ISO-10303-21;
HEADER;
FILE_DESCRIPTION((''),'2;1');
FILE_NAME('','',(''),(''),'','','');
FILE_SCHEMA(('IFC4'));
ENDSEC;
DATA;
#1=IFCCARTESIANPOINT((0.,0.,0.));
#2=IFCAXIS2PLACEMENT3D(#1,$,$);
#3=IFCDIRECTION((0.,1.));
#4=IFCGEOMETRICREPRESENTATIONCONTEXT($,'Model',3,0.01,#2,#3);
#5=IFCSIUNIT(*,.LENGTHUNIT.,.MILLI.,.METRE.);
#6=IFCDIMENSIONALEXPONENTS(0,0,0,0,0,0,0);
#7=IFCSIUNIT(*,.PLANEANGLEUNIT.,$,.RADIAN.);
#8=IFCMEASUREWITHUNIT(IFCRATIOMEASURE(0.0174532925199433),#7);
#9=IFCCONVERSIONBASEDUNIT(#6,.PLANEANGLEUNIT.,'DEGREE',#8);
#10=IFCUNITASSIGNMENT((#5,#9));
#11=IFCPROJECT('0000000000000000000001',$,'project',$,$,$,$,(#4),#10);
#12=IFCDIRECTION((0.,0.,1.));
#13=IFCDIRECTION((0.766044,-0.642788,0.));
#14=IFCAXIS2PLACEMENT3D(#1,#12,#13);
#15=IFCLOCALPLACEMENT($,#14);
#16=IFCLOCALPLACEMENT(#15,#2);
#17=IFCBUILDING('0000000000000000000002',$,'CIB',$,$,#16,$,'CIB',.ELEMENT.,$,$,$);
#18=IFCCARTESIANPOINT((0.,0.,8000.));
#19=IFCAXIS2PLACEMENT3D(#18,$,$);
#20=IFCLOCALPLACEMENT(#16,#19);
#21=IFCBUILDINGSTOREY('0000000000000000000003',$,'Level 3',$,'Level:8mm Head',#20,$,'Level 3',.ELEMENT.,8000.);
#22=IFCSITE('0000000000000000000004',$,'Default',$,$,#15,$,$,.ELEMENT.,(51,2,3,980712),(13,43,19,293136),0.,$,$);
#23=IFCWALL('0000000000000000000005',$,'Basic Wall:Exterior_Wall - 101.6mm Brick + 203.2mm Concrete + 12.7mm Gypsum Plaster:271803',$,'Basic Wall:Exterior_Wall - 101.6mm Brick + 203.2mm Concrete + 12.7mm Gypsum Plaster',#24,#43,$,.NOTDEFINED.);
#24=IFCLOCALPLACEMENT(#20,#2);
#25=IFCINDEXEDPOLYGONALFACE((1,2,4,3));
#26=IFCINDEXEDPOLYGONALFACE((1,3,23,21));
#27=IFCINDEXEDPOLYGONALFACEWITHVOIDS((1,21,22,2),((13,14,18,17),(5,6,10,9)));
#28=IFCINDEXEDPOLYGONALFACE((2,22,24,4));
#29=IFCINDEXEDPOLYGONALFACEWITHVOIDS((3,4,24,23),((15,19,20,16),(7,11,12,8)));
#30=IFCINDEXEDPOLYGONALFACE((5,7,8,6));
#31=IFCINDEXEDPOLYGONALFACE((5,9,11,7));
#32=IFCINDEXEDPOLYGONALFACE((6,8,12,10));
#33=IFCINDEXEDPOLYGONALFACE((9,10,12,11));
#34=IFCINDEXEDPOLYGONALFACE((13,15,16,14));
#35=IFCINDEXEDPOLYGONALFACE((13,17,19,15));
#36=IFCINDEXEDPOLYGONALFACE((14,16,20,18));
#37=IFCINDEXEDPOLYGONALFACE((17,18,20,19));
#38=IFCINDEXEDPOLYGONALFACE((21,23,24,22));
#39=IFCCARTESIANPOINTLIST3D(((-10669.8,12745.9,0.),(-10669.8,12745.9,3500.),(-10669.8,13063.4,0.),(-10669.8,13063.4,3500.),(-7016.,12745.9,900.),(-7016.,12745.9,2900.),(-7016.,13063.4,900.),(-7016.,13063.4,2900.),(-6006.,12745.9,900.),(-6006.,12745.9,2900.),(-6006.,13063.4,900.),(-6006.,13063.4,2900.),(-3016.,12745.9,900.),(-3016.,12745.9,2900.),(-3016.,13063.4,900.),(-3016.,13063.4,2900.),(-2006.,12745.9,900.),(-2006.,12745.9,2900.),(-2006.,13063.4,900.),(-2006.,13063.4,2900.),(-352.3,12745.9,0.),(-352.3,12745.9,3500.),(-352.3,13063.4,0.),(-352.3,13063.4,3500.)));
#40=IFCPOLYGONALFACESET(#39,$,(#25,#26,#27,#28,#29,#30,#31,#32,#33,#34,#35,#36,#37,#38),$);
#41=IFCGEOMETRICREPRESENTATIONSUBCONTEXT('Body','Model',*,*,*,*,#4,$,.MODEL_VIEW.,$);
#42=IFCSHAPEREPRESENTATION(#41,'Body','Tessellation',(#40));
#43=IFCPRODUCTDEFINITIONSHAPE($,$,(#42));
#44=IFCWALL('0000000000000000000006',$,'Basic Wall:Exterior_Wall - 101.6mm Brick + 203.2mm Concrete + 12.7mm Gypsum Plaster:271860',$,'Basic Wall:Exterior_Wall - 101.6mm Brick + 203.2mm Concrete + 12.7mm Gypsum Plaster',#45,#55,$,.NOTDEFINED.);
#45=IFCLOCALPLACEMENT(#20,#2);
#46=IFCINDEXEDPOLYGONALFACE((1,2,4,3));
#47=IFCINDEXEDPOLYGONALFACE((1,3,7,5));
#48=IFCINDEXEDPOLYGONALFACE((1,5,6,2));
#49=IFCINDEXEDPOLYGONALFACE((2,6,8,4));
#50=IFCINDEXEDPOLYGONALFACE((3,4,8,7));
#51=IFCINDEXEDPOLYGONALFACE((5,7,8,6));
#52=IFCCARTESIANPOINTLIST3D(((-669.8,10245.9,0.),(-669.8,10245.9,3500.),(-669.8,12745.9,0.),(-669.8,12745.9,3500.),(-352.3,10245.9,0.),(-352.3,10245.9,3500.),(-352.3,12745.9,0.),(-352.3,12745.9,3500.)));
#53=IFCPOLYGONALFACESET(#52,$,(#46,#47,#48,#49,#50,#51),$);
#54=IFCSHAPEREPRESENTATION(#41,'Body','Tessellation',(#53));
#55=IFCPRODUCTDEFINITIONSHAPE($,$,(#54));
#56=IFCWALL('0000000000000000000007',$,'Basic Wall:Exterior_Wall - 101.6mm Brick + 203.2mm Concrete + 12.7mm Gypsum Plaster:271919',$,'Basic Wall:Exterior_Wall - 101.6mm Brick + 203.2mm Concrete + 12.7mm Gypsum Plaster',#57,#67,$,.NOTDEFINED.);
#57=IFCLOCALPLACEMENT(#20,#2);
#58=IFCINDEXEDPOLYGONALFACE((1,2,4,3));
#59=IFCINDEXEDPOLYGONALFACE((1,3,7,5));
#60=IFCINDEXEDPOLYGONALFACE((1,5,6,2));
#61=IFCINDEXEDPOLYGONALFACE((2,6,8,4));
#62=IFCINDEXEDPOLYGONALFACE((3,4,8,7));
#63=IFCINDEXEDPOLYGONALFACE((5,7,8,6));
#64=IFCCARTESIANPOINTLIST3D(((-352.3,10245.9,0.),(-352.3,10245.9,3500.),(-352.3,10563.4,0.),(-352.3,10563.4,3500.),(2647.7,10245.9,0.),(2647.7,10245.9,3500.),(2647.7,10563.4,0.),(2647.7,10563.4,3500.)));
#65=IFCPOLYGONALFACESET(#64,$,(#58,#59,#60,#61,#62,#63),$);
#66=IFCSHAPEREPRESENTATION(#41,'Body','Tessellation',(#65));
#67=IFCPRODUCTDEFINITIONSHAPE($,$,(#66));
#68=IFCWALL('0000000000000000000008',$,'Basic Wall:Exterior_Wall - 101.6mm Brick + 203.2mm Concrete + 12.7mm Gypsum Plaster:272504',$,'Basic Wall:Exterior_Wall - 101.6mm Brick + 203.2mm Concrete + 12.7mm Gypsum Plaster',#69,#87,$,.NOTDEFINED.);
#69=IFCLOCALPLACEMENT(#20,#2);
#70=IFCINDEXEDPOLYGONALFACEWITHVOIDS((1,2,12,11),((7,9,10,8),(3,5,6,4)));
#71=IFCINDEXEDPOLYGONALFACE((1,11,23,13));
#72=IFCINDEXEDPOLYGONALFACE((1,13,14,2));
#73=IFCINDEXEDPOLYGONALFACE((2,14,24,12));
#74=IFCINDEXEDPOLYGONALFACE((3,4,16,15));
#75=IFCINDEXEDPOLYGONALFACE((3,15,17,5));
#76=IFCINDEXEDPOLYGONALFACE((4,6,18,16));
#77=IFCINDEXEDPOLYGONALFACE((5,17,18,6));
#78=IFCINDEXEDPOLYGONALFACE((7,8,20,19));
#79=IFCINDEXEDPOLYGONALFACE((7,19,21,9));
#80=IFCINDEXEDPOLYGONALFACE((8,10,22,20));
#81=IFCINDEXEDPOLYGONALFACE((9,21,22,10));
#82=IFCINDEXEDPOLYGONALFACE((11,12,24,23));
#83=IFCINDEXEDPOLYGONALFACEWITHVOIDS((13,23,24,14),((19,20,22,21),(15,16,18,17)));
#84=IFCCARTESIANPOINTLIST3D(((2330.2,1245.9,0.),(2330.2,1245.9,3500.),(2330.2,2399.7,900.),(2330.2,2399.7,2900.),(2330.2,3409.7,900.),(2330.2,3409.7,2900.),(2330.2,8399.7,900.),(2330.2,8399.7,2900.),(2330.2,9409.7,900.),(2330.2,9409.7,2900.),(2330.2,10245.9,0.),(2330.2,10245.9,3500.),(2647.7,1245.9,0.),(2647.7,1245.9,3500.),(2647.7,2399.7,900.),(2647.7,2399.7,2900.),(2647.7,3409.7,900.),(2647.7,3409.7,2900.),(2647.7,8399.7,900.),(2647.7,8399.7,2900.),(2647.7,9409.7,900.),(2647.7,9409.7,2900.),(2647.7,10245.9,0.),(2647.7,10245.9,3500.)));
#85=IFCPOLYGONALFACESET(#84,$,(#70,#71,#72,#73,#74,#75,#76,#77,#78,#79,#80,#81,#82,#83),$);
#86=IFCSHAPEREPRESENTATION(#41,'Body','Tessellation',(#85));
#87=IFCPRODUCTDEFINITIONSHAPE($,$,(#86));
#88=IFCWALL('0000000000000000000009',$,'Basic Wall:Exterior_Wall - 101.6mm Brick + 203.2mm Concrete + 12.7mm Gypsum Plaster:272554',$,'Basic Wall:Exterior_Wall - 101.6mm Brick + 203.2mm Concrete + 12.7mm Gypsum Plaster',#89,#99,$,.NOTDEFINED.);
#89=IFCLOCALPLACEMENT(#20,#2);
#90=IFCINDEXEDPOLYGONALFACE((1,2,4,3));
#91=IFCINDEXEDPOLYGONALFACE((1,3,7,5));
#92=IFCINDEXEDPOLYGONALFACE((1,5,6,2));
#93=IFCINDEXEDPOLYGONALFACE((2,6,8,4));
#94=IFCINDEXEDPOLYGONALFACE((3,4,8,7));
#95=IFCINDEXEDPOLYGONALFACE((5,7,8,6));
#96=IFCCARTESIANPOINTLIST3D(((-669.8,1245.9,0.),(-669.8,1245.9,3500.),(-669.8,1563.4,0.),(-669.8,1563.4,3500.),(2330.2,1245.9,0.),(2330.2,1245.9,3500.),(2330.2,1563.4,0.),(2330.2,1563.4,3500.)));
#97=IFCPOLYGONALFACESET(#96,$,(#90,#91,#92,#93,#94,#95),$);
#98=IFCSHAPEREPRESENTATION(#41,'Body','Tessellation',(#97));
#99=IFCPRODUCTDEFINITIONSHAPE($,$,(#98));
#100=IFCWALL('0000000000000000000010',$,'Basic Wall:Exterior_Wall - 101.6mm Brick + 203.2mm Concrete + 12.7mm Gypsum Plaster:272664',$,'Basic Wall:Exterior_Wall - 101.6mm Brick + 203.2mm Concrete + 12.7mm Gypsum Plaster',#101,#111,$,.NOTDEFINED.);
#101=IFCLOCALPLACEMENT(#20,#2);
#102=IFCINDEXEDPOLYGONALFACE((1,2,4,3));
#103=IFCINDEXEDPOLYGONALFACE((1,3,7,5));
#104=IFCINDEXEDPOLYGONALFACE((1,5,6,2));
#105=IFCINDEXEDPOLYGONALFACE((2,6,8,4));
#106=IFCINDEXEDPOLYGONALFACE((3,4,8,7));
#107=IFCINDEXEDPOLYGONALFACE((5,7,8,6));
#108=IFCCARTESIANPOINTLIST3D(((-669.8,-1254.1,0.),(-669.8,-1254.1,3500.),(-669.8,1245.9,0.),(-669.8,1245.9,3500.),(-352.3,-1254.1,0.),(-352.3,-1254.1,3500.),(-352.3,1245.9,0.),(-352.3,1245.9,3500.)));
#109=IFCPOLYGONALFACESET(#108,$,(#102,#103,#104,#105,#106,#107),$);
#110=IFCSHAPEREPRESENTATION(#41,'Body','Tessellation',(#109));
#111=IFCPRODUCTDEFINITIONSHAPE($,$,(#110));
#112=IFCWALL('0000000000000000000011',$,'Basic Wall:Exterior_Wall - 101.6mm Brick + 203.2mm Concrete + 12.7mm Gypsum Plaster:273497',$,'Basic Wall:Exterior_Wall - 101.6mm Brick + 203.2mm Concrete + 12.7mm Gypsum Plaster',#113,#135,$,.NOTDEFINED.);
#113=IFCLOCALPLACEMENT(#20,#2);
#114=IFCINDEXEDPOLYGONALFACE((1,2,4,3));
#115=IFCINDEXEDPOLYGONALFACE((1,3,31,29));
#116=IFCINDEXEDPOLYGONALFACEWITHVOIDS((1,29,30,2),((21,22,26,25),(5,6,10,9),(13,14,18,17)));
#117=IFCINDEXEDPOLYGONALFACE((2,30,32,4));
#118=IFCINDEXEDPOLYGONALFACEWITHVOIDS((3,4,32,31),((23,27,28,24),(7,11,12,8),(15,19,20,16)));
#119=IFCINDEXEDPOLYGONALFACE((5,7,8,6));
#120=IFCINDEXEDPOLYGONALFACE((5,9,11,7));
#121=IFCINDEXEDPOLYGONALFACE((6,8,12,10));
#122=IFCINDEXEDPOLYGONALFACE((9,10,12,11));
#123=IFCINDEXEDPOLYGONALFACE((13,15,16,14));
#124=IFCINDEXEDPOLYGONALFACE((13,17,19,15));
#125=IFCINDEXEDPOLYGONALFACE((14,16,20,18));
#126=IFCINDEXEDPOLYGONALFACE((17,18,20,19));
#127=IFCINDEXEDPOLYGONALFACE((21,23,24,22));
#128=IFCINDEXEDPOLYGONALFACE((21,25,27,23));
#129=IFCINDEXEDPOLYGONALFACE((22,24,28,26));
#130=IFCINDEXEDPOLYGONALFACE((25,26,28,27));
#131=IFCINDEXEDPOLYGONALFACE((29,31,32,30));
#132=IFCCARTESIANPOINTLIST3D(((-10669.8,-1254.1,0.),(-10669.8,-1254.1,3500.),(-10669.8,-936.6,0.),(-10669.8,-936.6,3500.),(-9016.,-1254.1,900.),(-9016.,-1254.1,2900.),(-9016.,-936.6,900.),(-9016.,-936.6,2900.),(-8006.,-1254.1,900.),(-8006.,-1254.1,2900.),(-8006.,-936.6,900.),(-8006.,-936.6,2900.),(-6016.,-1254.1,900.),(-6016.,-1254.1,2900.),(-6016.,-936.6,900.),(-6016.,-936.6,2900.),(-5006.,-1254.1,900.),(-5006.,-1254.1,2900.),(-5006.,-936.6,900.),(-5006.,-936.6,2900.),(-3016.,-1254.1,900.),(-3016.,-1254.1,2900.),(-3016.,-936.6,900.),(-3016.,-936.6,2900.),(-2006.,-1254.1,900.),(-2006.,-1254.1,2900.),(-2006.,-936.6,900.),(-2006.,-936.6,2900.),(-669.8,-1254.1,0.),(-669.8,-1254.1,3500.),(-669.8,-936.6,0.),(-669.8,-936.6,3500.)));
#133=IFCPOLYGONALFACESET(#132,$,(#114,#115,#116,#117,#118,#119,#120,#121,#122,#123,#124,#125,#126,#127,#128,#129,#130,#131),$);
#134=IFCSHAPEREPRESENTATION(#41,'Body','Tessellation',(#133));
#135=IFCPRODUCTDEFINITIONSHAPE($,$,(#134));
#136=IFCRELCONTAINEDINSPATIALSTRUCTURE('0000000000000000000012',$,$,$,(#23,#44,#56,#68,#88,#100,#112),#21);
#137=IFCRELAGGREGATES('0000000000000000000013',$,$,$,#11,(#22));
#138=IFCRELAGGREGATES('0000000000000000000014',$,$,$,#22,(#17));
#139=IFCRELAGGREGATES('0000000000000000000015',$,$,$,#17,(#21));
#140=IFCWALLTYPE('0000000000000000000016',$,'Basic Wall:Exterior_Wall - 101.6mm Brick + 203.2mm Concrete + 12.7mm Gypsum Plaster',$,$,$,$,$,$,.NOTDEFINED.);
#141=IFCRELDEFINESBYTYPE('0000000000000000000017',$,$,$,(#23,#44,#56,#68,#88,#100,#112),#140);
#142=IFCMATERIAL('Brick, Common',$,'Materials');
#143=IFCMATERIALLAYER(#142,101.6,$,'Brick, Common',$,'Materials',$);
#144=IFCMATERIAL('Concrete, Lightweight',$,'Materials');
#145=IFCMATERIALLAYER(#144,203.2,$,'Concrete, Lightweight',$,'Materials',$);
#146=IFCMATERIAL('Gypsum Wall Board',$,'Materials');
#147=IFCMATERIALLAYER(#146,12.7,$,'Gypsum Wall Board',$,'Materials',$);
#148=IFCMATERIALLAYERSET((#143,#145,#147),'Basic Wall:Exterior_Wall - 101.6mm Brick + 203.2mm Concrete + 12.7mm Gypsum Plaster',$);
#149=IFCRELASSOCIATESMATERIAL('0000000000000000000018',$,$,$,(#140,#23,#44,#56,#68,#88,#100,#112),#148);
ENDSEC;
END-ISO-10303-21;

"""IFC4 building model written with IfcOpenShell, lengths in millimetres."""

from ifc_helpers import new_model, entity, si_unit, converted_unit, direction, frame, frame_2d, origin, place, context, subcontext, project, spatial, rectangle, extrude, material, layer, layer_set, layer_usage, type_object, element, save


model = new_model("IFC4")

# Units and contexts
model_context = context("Model", 3, precision=0.01, world=origin(), true_north=direction((0.0, 1.0)))
body_context = subcontext(model_context, "Body", "Model", "MODEL_VIEW")
ifc_project = project(units=[si_unit("LENGTHUNIT", "METRE", prefix="MILLI"), converted_unit("PLANEANGLEUNIT", "DEGREE", entity("IfcRatioMeasure", 0.0174532925199433), si_unit("PLANEANGLEUNIT", "RADIAN"), dimensions=[0, 0, 0, 0, 0, 0, 0])], contexts=[model_context])

# Site, building, storey
site_placement = place(None, frame((0.0, 0.0, 0.0), z_axis=(0.0, 0.0, 1.0), x_axis=(0.766044, -0.642788, 0.0)))
site = spatial("IfcSite", under=ifc_project, at=site_placement, Name="Default", CompositionType="ELEMENT", RefLatitude=(51, 2, 3, 980712), RefLongitude=(13, 43, 19, 293136), RefElevation=0.0)
building_placement = place(site_placement, origin())
building = spatial("IfcBuilding", under=site, at=building_placement, Name="CIB", LongName="CIB", CompositionType="ELEMENT")
storey_placement = place(building_placement, frame((0.0, 0.0, 8000.0)))
storey = spatial("IfcBuildingStorey", under=building, at=storey_placement, Name="Level 3", ObjectType="Level:8mm Head", LongName="Level 3", CompositionType="ELEMENT", Elevation=8000.0)

# Wall, openings
ifc_material_1 = material(Name="Brick, Common", Category="Materials")
ifc_layer_1 = layer(ifc_material_1, 101.6, Name="Brick, Common", Category="Materials")
ifc_material_2 = material(Name="Concrete, Lightweight", Category="Materials")
ifc_layer_2 = layer(ifc_material_2, 203.2, Name="Concrete, Lightweight", Category="Materials")
ifc_material_3 = material(Name="Gypsum Wall Board", Category="Materials")
ifc_layer_3 = layer(ifc_material_3, 12.7, Name="Gypsum Wall Board", Category="Materials")
ifc_layer_set_1 = layer_set([ifc_layer_1, ifc_layer_2, ifc_layer_3], Name="Basic Wall:Exterior_Wall - 101.6mm Brick + 203.2mm Concrete + 12.7mm Gypsum Plaster")
ifc_layer_usage_1 = layer_usage(ifc_layer_set_1, "AXIS2", "NEGATIVE", 158.8)
wall_type_1 = type_object("IfcWallType", Name="Basic Wall:Exterior_Wall - 101.6mm Brick + 203.2mm Concrete + 12.7mm Gypsum Plaster", PredefinedType="NOTDEFINED", material=ifc_layer_set_1)
wall_1_placement = place(storey_placement, frame((-10669.8, 12904.7, 0.0)))
wall_1 = element("IfcWall", 1, at=wall_1_placement, inside=storey, type_object=wall_type_1, material=ifc_layer_usage_1, Name="Basic Wall:Exterior_Wall - 101.6mm Brick + 203.2mm Concrete + 12.7mm Gypsum Plaster:271803", ObjectType="Basic Wall:Exterior_Wall - 101.6mm Brick + 203.2mm Concrete + 12.7mm Gypsum Plaster", PredefinedType="NOTDEFINED", context=body_context, shape_type="SweptSolid", body=[
    extrude(rectangle(XDim=10317.5, YDim=317.5, at=frame_2d((5158.7, 0.0), x_axis=(-1.0, 0.0))), origin(), (0.0, 0.0, 1.0), 3500.0),
])
opening_1_placement = place(wall_1_placement, frame((8663.7, 158.7, 900.0)))
element("IfcOpeningElement", 2, at=opening_1_placement, cuts=wall_1, ObjectType="Opening", PredefinedType="OPENING", context=body_context, shape_type="SweptSolid", body=[
    extrude(rectangle(XDim=2000.0, YDim=1010.0, at=frame_2d((1000.0, 505.0), x_axis=(1.0, 0.0))), frame((0.0, 0.0, 0.0), z_axis=(0.0, -1.0, 0.0), x_axis=(0.0, 0.0, 1.0)), (0.0, 0.0, 1.0), 317.5),
])
opening_2_placement = place(wall_1_placement, frame((4663.7, 158.7, 900.0)))
element("IfcOpeningElement", 3, at=opening_2_placement, cuts=wall_1, ObjectType="Opening", PredefinedType="OPENING", context=body_context, shape_type="SweptSolid", body=[
    extrude(rectangle(XDim=2000.0, YDim=1010.0, at=frame_2d((1000.0, 505.0), x_axis=(1.0, 0.0))), frame((0.0, 0.0, 0.0), z_axis=(0.0, -1.0, 0.0), x_axis=(0.0, 0.0, 1.0)), (0.0, 0.0, 1.0), 317.5),
])

# Walls
ifc_layer_usage_2 = layer_usage(ifc_layer_set_1, "AXIS2", "NEGATIVE", 158.8)
wall_2_placement = place(storey_placement, frame((-511.0, 12745.9, 0.0), z_axis=(0.0, 0.0, 1.0), x_axis=(0.0, -1.0, 0.0)))
element("IfcWall", 4, at=wall_2_placement, inside=storey, type_object=wall_type_1, material=ifc_layer_usage_2, Name="Basic Wall:Exterior_Wall - 101.6mm Brick + 203.2mm Concrete + 12.7mm Gypsum Plaster:271860", ObjectType="Basic Wall:Exterior_Wall - 101.6mm Brick + 203.2mm Concrete + 12.7mm Gypsum Plaster", PredefinedType="NOTDEFINED", context=body_context, shape_type="SweptSolid", body=[
    extrude(rectangle(XDim=2500.0, YDim=317.5, at=frame_2d((1250.0, 0.0), x_axis=(-1.0, 0.0))), origin(), (0.0, 0.0, 1.0), 3500.0),
])
ifc_layer_usage_3 = layer_usage(ifc_layer_set_1, "AXIS2", "NEGATIVE", 158.8)
wall_3_placement = place(storey_placement, frame((-352.3, 10404.7, 0.0)))
element("IfcWall", 5, at=wall_3_placement, inside=storey, type_object=wall_type_1, material=ifc_layer_usage_3, Name="Basic Wall:Exterior_Wall - 101.6mm Brick + 203.2mm Concrete + 12.7mm Gypsum Plaster:271919", ObjectType="Basic Wall:Exterior_Wall - 101.6mm Brick + 203.2mm Concrete + 12.7mm Gypsum Plaster", PredefinedType="NOTDEFINED", context=body_context, shape_type="SweptSolid", body=[
    extrude(rectangle(XDim=3000.0, YDim=317.5, at=frame_2d((1500.0, 0.0), x_axis=(-1.0, 0.0))), origin(), (0.0, 0.0, 1.0), 3500.0),
])

# Wall, openings
ifc_layer_usage_4 = layer_usage(ifc_layer_set_1, "AXIS2", "NEGATIVE", 158.8)
wall_4_placement = place(storey_placement, frame((2489.0, 10245.9, 0.0), z_axis=(0.0, 0.0, 1.0), x_axis=(0.0, -1.0, 0.0)))
wall_4 = element("IfcWall", 6, at=wall_4_placement, inside=storey, type_object=wall_type_1, material=ifc_layer_usage_4, Name="Basic Wall:Exterior_Wall - 101.6mm Brick + 203.2mm Concrete + 12.7mm Gypsum Plaster:272504", ObjectType="Basic Wall:Exterior_Wall - 101.6mm Brick + 203.2mm Concrete + 12.7mm Gypsum Plaster", PredefinedType="NOTDEFINED", context=body_context, shape_type="SweptSolid", body=[
    extrude(rectangle(XDim=9000.0, YDim=317.5, at=frame_2d((4500.0, 0.0), x_axis=(-1.0, 0.0))), origin(), (0.0, 0.0, 1.0), 3500.0),
])
opening_3_placement = place(wall_4_placement, frame((1846.2, 158.7, 900.0)))
element("IfcOpeningElement", 7, at=opening_3_placement, cuts=wall_4, ObjectType="Opening", PredefinedType="OPENING", context=body_context, shape_type="SweptSolid", body=[
    extrude(rectangle(XDim=2000.0, YDim=1010.0, at=frame_2d((1000.0, 505.0), x_axis=(1.0, 0.0))), frame((0.0, 0.0, 0.0), z_axis=(0.0, -1.0, 0.0), x_axis=(0.0, 0.0, 1.0)), (0.0, 0.0, 1.0), 317.5),
])
opening_4_placement = place(wall_4_placement, frame((7846.2, 158.7, 900.0)))
element("IfcOpeningElement", 8, at=opening_4_placement, cuts=wall_4, ObjectType="Opening", PredefinedType="OPENING", context=body_context, shape_type="SweptSolid", body=[
    extrude(rectangle(XDim=2000.0, YDim=1010.0, at=frame_2d((1000.0, 505.0), x_axis=(1.0, 0.0))), frame((0.0, 0.0, 0.0), z_axis=(0.0, -1.0, 0.0), x_axis=(0.0, 0.0, 1.0)), (0.0, 0.0, 1.0), 317.5),
])

# Walls
ifc_layer_usage_5 = layer_usage(ifc_layer_set_1, "AXIS2", "NEGATIVE", 158.8)
wall_5_placement = place(storey_placement, frame((2330.2, 1404.7, 0.0), z_axis=(0.0, 0.0, 1.0), x_axis=(-1.0, 0.0, 0.0)))
element("IfcWall", 9, at=wall_5_placement, inside=storey, type_object=wall_type_1, material=ifc_layer_usage_5, Name="Basic Wall:Exterior_Wall - 101.6mm Brick + 203.2mm Concrete + 12.7mm Gypsum Plaster:272554", ObjectType="Basic Wall:Exterior_Wall - 101.6mm Brick + 203.2mm Concrete + 12.7mm Gypsum Plaster", PredefinedType="NOTDEFINED", context=body_context, shape_type="SweptSolid", body=[
    extrude(rectangle(XDim=3000.0, YDim=317.5, at=frame_2d((1500.0, 0.0), x_axis=(-1.0, 0.0))), origin(), (0.0, 0.0, 1.0), 3500.0),
])
ifc_layer_usage_6 = layer_usage(ifc_layer_set_1, "AXIS2", "NEGATIVE", 158.8)
wall_6_placement = place(storey_placement, frame((-511.0, 1245.9, 0.0), z_axis=(0.0, 0.0, 1.0), x_axis=(0.0, -1.0, 0.0)))
element("IfcWall", 10, at=wall_6_placement, inside=storey, type_object=wall_type_1, material=ifc_layer_usage_6, Name="Basic Wall:Exterior_Wall - 101.6mm Brick + 203.2mm Concrete + 12.7mm Gypsum Plaster:272664", ObjectType="Basic Wall:Exterior_Wall - 101.6mm Brick + 203.2mm Concrete + 12.7mm Gypsum Plaster", PredefinedType="NOTDEFINED", context=body_context, shape_type="SweptSolid", body=[
    extrude(rectangle(XDim=2500.0, YDim=317.5, at=frame_2d((1250.0, 0.0), x_axis=(-1.0, 0.0))), origin(), (0.0, 0.0, 1.0), 3500.0),
])

# Wall, openings
ifc_layer_usage_7 = layer_usage(ifc_layer_set_1, "AXIS2", "NEGATIVE", 158.8)
wall_7_placement = place(storey_placement, frame((-669.8, -1095.3, 0.0), z_axis=(0.0, 0.0, 1.0), x_axis=(-1.0, 0.0, 0.0)))
wall_7 = element("IfcWall", 11, at=wall_7_placement, inside=storey, type_object=wall_type_1, material=ifc_layer_usage_7, Name="Basic Wall:Exterior_Wall - 101.6mm Brick + 203.2mm Concrete + 12.7mm Gypsum Plaster:273497", ObjectType="Basic Wall:Exterior_Wall - 101.6mm Brick + 203.2mm Concrete + 12.7mm Gypsum Plaster", PredefinedType="NOTDEFINED", context=body_context, shape_type="SweptSolid", body=[
    extrude(rectangle(XDim=10000.0, YDim=317.5, at=frame_2d((5000.0, 0.0), x_axis=(-1.0, 0.0))), origin(), (0.0, 0.0, 1.0), 3500.0),
])
opening_5_placement = place(wall_7_placement, frame((2346.2, 158.7, 900.0)))
element("IfcOpeningElement", 12, at=opening_5_placement, cuts=wall_7, ObjectType="Opening", PredefinedType="OPENING", context=body_context, shape_type="SweptSolid", body=[
    extrude(rectangle(XDim=2000.0, YDim=1010.0, at=frame_2d((1000.0, 505.0), x_axis=(1.0, 0.0))), frame((0.0, 0.0, 0.0), z_axis=(0.0, -1.0, 0.0), x_axis=(0.0, 0.0, 1.0)), (0.0, 0.0, 1.0), 317.5),
])
opening_6_placement = place(wall_7_placement, frame((8346.2, 158.7, 900.0)))
element("IfcOpeningElement", 13, at=opening_6_placement, cuts=wall_7, ObjectType="Opening", PredefinedType="OPENING", context=body_context, shape_type="SweptSolid", body=[
    extrude(rectangle(XDim=2000.0, YDim=1010.0, at=frame_2d((1000.0, 505.0), x_axis=(1.0, 0.0))), frame((0.0, 0.0, 0.0), z_axis=(0.0, -1.0, 0.0), x_axis=(0.0, 0.0, 1.0)), (0.0, 0.0, 1.0), 317.5),
])
opening_7_placement = place(wall_7_placement, frame((5346.2, 158.7, 900.0)))
element("IfcOpeningElement", 14, at=opening_7_placement, cuts=wall_7, ObjectType="Opening", PredefinedType="OPENING", context=body_context, shape_type="SweptSolid", body=[
    extrude(rectangle(XDim=2000.0, YDim=1010.0, at=frame_2d((1000.0, 505.0), x_axis=(1.0, 0.0))), frame((0.0, 0.0, 0.0), z_axis=(0.0, -1.0, 0.0), x_axis=(0.0, 0.0, 1.0)), (0.0, 0.0, 1.0), 317.5),
])

save(model, "model.ifc")
